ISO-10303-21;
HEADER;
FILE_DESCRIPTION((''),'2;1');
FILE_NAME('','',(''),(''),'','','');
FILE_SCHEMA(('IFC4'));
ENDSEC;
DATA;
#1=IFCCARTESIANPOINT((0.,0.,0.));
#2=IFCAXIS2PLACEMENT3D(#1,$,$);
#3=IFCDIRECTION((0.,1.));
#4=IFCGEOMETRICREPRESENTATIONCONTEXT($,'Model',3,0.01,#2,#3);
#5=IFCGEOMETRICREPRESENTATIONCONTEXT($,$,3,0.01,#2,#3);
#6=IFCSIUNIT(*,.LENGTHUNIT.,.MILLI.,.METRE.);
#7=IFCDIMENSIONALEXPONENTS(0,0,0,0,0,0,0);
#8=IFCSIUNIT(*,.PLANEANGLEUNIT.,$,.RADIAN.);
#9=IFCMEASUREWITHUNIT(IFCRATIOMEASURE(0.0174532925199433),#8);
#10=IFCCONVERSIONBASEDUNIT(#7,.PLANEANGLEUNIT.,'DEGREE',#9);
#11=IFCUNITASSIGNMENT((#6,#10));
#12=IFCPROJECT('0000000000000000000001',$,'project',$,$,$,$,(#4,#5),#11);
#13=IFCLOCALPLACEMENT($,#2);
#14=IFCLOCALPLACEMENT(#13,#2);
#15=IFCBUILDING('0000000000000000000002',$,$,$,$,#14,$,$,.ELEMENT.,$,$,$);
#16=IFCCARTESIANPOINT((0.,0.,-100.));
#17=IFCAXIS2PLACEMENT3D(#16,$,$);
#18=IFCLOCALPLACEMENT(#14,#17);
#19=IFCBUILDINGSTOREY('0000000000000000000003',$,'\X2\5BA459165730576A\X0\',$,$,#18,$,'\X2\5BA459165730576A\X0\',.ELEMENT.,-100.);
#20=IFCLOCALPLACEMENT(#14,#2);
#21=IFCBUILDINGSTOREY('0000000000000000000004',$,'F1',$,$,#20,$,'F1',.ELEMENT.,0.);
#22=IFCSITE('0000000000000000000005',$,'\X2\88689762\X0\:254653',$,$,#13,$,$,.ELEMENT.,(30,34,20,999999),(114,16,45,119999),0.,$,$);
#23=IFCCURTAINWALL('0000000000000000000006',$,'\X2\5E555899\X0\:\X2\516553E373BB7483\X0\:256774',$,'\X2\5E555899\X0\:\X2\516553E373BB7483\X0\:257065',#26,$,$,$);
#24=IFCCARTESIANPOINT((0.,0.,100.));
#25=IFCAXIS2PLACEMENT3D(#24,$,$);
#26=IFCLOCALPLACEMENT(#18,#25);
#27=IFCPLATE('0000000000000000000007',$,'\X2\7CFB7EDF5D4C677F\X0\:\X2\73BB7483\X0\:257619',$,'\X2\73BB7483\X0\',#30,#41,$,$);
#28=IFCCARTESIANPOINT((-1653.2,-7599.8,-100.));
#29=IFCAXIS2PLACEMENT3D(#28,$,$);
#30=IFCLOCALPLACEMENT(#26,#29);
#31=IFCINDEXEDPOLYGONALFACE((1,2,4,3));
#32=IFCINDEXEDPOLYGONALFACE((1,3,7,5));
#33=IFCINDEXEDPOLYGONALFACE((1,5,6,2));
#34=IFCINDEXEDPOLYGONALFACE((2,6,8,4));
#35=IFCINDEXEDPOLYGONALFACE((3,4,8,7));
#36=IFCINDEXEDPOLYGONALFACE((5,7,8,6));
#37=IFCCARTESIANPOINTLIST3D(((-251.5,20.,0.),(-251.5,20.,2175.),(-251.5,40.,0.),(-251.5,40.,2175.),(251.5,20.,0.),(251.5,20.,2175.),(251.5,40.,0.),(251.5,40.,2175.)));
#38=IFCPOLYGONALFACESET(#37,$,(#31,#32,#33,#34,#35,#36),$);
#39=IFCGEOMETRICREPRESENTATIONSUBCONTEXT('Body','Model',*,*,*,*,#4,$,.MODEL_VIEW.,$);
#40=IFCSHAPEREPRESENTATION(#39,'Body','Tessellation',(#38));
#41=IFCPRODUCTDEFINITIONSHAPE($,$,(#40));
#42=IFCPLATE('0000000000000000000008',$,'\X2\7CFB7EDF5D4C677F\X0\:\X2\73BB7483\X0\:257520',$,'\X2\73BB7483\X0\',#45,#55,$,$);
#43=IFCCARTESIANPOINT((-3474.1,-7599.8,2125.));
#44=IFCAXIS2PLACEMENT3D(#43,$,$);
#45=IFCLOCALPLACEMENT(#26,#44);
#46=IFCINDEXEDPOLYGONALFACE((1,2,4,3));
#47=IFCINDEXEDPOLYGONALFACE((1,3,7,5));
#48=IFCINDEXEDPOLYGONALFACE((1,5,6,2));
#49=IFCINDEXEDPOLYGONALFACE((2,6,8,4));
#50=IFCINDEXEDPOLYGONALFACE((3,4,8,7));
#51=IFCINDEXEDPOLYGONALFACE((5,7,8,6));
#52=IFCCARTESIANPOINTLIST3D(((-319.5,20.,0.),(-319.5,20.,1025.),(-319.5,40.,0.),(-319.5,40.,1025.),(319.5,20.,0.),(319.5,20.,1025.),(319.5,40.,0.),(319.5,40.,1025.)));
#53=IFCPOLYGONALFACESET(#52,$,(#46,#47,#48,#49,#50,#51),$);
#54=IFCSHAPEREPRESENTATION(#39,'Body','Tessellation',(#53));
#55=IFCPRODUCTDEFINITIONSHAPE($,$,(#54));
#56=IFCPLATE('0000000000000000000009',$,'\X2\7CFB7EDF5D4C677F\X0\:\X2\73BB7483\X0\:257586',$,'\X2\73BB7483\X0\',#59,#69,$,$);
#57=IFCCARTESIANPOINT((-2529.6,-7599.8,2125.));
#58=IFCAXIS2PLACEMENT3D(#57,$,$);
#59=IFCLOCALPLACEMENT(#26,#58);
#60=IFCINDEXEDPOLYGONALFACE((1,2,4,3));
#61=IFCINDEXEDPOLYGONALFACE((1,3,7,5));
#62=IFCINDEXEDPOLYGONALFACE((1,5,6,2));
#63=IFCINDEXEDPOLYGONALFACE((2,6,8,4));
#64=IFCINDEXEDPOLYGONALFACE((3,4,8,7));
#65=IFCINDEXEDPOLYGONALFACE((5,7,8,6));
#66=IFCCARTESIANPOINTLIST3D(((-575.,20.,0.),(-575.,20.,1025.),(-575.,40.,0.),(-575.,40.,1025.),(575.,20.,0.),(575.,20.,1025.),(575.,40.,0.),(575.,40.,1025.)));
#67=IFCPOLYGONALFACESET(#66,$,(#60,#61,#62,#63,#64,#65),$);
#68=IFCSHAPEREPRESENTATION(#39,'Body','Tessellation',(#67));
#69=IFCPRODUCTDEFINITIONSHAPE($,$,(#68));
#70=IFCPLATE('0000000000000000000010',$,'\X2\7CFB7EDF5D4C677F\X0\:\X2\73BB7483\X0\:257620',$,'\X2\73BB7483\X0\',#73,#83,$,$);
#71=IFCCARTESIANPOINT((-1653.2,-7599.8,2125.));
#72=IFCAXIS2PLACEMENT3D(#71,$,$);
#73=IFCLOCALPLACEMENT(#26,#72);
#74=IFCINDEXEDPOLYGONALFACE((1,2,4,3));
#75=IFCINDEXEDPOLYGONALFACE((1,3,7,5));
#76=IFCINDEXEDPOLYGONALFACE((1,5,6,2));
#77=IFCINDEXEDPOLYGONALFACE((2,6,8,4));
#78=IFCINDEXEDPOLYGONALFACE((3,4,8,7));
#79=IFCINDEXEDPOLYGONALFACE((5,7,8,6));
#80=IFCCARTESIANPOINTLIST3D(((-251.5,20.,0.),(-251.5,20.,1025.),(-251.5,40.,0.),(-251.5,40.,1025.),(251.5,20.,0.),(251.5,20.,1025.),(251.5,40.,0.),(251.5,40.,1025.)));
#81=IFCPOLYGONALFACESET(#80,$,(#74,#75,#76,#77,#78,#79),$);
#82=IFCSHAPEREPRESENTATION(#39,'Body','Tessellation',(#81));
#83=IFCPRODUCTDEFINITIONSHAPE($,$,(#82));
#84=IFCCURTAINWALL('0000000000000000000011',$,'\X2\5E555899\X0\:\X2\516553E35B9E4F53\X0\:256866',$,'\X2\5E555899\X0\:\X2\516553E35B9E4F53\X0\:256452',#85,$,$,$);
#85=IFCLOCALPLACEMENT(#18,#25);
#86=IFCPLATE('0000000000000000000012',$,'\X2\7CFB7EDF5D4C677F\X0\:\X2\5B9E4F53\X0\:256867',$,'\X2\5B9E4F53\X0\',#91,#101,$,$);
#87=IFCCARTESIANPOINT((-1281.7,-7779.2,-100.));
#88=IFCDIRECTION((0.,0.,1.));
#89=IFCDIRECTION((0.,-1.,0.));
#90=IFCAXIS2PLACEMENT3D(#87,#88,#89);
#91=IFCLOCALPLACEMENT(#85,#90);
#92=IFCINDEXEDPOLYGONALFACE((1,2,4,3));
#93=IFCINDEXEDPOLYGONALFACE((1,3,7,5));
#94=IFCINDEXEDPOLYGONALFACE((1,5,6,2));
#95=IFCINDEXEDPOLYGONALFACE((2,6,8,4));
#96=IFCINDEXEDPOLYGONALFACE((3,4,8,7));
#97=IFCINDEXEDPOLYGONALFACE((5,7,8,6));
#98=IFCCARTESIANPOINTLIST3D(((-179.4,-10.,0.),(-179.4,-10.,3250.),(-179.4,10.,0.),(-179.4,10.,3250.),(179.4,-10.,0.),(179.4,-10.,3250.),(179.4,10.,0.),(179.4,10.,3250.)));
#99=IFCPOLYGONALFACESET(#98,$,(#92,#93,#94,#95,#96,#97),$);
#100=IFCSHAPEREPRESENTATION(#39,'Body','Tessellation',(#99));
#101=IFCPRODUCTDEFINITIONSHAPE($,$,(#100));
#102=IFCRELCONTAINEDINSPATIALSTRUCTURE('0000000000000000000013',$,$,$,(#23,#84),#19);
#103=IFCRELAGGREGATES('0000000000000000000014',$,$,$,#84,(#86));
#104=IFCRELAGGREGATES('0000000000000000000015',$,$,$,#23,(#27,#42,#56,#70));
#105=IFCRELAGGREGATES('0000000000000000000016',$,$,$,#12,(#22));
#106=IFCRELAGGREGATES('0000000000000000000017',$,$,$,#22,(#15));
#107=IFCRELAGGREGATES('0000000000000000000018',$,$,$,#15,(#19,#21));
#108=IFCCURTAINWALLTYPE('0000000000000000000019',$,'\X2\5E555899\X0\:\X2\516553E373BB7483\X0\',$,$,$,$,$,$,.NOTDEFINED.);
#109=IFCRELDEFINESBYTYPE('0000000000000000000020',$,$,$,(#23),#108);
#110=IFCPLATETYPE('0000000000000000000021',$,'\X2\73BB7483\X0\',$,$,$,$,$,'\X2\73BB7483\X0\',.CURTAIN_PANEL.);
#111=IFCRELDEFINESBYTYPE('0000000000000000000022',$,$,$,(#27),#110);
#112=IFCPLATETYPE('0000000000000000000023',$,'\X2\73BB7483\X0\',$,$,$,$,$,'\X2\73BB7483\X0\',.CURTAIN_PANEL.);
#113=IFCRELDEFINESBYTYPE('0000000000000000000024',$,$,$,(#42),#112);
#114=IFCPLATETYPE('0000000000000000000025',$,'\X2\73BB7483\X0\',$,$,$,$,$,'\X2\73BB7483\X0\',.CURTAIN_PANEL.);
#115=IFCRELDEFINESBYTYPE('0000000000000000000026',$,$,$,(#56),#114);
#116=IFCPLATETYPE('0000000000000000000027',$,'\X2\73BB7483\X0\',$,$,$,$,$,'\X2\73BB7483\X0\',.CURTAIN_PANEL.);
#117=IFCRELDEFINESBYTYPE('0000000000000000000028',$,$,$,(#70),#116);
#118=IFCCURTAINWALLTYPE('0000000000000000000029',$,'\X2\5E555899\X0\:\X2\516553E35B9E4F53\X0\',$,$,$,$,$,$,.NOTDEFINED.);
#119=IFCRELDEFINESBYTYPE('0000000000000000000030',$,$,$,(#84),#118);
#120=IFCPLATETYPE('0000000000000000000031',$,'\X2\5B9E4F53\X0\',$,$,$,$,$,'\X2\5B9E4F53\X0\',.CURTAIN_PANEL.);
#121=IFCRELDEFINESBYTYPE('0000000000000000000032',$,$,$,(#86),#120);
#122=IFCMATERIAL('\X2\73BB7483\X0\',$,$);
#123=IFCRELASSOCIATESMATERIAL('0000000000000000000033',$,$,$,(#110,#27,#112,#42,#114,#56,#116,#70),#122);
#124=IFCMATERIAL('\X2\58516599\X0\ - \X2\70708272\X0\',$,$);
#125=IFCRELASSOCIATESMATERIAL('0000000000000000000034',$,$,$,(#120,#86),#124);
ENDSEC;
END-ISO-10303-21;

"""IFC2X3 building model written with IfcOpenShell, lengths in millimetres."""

from ifc_helpers import new_model, entity, si_unit, converted_unit, direction, frame, frame_2d, origin, origin_2d_with_axis, place, context, subcontext, project, spatial, rectangle, extrude, source, transform, mapped, material, type_object, type_shapes, element, aggregate, save


model = new_model("IFC2X3")

# Units and contexts
model_context = context("Model", 3, precision=0.01, world=origin(), true_north=direction((0.0, 1.0)))
context_of_model = context(None, 3, precision=0.01, world=origin(), true_north=direction((0.0, 1.0)))
body_context = subcontext(model_context, "Body", "Model", "MODEL_VIEW")
ifc_project = project(units=[si_unit("LENGTHUNIT", "METRE", prefix="MILLI"), converted_unit("PLANEANGLEUNIT", "DEGREE", entity("IfcRatioMeasure", 0.0174532925199433), si_unit("PLANEANGLEUNIT", "RADIAN"), dimensions=[0, 0, 0, 0, 0, 0, 0])], contexts=[model_context, context_of_model])

# Site, building, storey
site_placement = place(None, origin())
site = spatial("IfcSite", under=ifc_project, at=site_placement, Name="表面:254653", CompositionType="ELEMENT", RefLatitude=(30, 34, 20, 999999), RefLongitude=(114, 16, 45, 119999), RefElevation=0.0)
building_placement = place(site_placement, origin())
building = spatial("IfcBuilding", under=site, at=building_placement, CompositionType="ELEMENT")
storey_1_placement = place(building_placement, frame((0.0, 0.0, -100.0)))
storey_1 = spatial("IfcBuildingStorey", under=building, at=storey_1_placement, Name="室外地坪", LongName="室外地坪", CompositionType="ELEMENT", Elevation=-100.0)

# Shared definitions
ifc_material_1 = material(Name="玻璃")

# Shared definitions
curtain_wall_type_1 = type_object("IfcCurtainWallType", Name="幕墙:入口实体", PredefinedType="NOTDEFINED")
ifc_material_2 = material(Name="塑料 - 灰色")

# Curtain wall, plates
curtain_wall_type_2 = type_object("IfcCurtainWallType", Name="幕墙:入口玻璃", PredefinedType="NOTDEFINED")
curtain_wall_1_placement = place(storey_1_placement, frame((0.0, 0.0, 100.0)))
curtain_wall_1 = element("IfcCurtainWall", 1, at=curtain_wall_1_placement, inside=storey_1, type_object=curtain_wall_type_2, Name="幕墙:入口玻璃:256774", ObjectType="幕墙:入口玻璃:257065")
plate_type_1 = type_object("IfcPlateType", Name="玻璃", ElementType="玻璃", PredefinedType="CURTAIN_PANEL", material=ifc_material_1)
shared_shape_1 = source(origin(), body_context, "Body", "SweptSolid", [
    extrude(rectangle(XDim=20.0, YDim=503.0, at=frame_2d((0.0, 0.0), x_axis=(1.0, 0.0))), frame((0.0, 30.0, 0.0), z_axis=(0.0, 0.0, 1.0), x_axis=(0.0, 1.0, 0.0)), (0.0, 0.0, 1.0), 2175.0),
])
type_shapes(plate_type_1, [shared_shape_1])
plate_1_placement = place(curtain_wall_1_placement, frame((-1653.2, -7599.8, -100.0)))
plate_1 = element("IfcPlate", 2, at=plate_1_placement, type_object=plate_type_1, material=ifc_material_1, Name="系统嵌板:玻璃:257619", ObjectType="玻璃", context=body_context, shape_type="MappedRepresentation", body=[
    mapped(shared_shape_1, transform((0.0, 0.0, 0.0), scale=1.0)),
])
plate_type_2 = type_object("IfcPlateType", Name="玻璃", ElementType="玻璃", PredefinedType="CURTAIN_PANEL", material=ifc_material_1)
shared_shape_2 = source(origin(), body_context, "Body", "SweptSolid", [
    extrude(rectangle(XDim=20.0, YDim=639.0, at=frame_2d((0.0, 0.0), x_axis=(1.0, 0.0))), frame((0.0, 30.0, 0.0), z_axis=(0.0, 0.0, 1.0), x_axis=(0.0, 1.0, 0.0)), (0.0, 0.0, 1.0), 1025.0),
])
type_shapes(plate_type_2, [shared_shape_2])
plate_2_placement = place(curtain_wall_1_placement, frame((-3474.1, -7599.8, 2125.0)))
plate_2 = element("IfcPlate", 3, at=plate_2_placement, type_object=plate_type_2, material=ifc_material_1, Name="系统嵌板:玻璃:257520", ObjectType="玻璃", context=body_context, shape_type="MappedRepresentation", body=[
    mapped(shared_shape_2, transform((0.0, 0.0, 0.0), scale=1.0)),
])
plate_type_3 = type_object("IfcPlateType", Name="玻璃", ElementType="玻璃", PredefinedType="CURTAIN_PANEL", material=ifc_material_1)
shared_shape_3 = source(origin(), body_context, "Body", "SweptSolid", [
    extrude(rectangle(XDim=20.0, YDim=1150.0, at=frame_2d((0.0, 0.0), x_axis=(1.0, 0.0))), frame((0.0, 30.0, 0.0), z_axis=(0.0, 0.0, 1.0), x_axis=(0.0, 1.0, 0.0)), (0.0, 0.0, 1.0), 1025.0),
])
type_shapes(plate_type_3, [shared_shape_3])
plate_3_placement = place(curtain_wall_1_placement, frame((-2529.6, -7599.8, 2125.0)))
plate_3 = element("IfcPlate", 4, at=plate_3_placement, type_object=plate_type_3, material=ifc_material_1, Name="系统嵌板:玻璃:257586", ObjectType="玻璃", context=body_context, shape_type="MappedRepresentation", body=[
    mapped(shared_shape_3, transform((0.0, 0.0, 0.0), scale=1.0)),
])
plate_type_4 = type_object("IfcPlateType", Name="玻璃", ElementType="玻璃", PredefinedType="CURTAIN_PANEL", material=ifc_material_1)
shared_shape_4 = source(origin(), body_context, "Body", "SweptSolid", [
    extrude(rectangle(XDim=20.0, YDim=503.0, at=frame_2d((0.0, 0.0), x_axis=(1.0, 0.0))), frame((0.0, 30.0, 0.0), z_axis=(0.0, 0.0, 1.0), x_axis=(0.0, 1.0, 0.0)), (0.0, 0.0, 1.0), 1025.0),
])
type_shapes(plate_type_4, [shared_shape_4])
plate_4_placement = place(curtain_wall_1_placement, frame((-1653.2, -7599.8, 2125.0)))
plate_4 = element("IfcPlate", 5, at=plate_4_placement, type_object=plate_type_4, material=ifc_material_1, Name="系统嵌板:玻璃:257620", ObjectType="玻璃", context=body_context, shape_type="MappedRepresentation", body=[
    mapped(shared_shape_4, transform((0.0, 0.0, 0.0), scale=1.0)),
])

# Curtain wall, plate
curtain_wall_2_placement = place(storey_1_placement, frame((0.0, 0.0, 100.0)))
curtain_wall_2 = element("IfcCurtainWall", 6, at=curtain_wall_2_placement, inside=storey_1, type_object=curtain_wall_type_1, Name="幕墙:入口实体:256866", ObjectType="幕墙:入口实体:256452")
plate_type_5 = type_object("IfcPlateType", Name="实体", ElementType="实体", PredefinedType="CURTAIN_PANEL", material=ifc_material_2)
shared_shape_5 = source(origin(), body_context, "Body", "SweptSolid", [
    extrude(rectangle(XDim=20.0, YDim=358.8, at=origin_2d_with_axis()), frame((0.0, 0.0, 0.0), z_axis=(0.0, 0.0, 1.0), x_axis=(0.0, 1.0, 0.0)), (0.0, 0.0, 1.0), 3250.0),
])
type_shapes(plate_type_5, [shared_shape_5])
plate_5_placement = place(curtain_wall_2_placement, frame((-1281.7, -7779.2, -100.0), z_axis=(0.0, 0.0, 1.0), x_axis=(0.0, -1.0, 0.0)))
plate_5 = element("IfcPlate", 7, at=plate_5_placement, type_object=plate_type_5, material=ifc_material_2, Name="系统嵌板:实体:256867", ObjectType="实体", context=body_context, shape_type="MappedRepresentation", body=[
    mapped(shared_shape_5, transform((0.0, 0.0, 0.0), scale=1.0)),
])
aggregate(curtain_wall_2, [plate_5])

# Shared definitions
storey_2_placement = place(building_placement, origin())
storey_2 = spatial("IfcBuildingStorey", under=building, at=storey_2_placement, Name="F1", LongName="F1", CompositionType="ELEMENT", Elevation=0.0)

aggregate(curtain_wall_1, [plate_1, plate_2, plate_3, plate_4])

save(model, "model.ifc")
